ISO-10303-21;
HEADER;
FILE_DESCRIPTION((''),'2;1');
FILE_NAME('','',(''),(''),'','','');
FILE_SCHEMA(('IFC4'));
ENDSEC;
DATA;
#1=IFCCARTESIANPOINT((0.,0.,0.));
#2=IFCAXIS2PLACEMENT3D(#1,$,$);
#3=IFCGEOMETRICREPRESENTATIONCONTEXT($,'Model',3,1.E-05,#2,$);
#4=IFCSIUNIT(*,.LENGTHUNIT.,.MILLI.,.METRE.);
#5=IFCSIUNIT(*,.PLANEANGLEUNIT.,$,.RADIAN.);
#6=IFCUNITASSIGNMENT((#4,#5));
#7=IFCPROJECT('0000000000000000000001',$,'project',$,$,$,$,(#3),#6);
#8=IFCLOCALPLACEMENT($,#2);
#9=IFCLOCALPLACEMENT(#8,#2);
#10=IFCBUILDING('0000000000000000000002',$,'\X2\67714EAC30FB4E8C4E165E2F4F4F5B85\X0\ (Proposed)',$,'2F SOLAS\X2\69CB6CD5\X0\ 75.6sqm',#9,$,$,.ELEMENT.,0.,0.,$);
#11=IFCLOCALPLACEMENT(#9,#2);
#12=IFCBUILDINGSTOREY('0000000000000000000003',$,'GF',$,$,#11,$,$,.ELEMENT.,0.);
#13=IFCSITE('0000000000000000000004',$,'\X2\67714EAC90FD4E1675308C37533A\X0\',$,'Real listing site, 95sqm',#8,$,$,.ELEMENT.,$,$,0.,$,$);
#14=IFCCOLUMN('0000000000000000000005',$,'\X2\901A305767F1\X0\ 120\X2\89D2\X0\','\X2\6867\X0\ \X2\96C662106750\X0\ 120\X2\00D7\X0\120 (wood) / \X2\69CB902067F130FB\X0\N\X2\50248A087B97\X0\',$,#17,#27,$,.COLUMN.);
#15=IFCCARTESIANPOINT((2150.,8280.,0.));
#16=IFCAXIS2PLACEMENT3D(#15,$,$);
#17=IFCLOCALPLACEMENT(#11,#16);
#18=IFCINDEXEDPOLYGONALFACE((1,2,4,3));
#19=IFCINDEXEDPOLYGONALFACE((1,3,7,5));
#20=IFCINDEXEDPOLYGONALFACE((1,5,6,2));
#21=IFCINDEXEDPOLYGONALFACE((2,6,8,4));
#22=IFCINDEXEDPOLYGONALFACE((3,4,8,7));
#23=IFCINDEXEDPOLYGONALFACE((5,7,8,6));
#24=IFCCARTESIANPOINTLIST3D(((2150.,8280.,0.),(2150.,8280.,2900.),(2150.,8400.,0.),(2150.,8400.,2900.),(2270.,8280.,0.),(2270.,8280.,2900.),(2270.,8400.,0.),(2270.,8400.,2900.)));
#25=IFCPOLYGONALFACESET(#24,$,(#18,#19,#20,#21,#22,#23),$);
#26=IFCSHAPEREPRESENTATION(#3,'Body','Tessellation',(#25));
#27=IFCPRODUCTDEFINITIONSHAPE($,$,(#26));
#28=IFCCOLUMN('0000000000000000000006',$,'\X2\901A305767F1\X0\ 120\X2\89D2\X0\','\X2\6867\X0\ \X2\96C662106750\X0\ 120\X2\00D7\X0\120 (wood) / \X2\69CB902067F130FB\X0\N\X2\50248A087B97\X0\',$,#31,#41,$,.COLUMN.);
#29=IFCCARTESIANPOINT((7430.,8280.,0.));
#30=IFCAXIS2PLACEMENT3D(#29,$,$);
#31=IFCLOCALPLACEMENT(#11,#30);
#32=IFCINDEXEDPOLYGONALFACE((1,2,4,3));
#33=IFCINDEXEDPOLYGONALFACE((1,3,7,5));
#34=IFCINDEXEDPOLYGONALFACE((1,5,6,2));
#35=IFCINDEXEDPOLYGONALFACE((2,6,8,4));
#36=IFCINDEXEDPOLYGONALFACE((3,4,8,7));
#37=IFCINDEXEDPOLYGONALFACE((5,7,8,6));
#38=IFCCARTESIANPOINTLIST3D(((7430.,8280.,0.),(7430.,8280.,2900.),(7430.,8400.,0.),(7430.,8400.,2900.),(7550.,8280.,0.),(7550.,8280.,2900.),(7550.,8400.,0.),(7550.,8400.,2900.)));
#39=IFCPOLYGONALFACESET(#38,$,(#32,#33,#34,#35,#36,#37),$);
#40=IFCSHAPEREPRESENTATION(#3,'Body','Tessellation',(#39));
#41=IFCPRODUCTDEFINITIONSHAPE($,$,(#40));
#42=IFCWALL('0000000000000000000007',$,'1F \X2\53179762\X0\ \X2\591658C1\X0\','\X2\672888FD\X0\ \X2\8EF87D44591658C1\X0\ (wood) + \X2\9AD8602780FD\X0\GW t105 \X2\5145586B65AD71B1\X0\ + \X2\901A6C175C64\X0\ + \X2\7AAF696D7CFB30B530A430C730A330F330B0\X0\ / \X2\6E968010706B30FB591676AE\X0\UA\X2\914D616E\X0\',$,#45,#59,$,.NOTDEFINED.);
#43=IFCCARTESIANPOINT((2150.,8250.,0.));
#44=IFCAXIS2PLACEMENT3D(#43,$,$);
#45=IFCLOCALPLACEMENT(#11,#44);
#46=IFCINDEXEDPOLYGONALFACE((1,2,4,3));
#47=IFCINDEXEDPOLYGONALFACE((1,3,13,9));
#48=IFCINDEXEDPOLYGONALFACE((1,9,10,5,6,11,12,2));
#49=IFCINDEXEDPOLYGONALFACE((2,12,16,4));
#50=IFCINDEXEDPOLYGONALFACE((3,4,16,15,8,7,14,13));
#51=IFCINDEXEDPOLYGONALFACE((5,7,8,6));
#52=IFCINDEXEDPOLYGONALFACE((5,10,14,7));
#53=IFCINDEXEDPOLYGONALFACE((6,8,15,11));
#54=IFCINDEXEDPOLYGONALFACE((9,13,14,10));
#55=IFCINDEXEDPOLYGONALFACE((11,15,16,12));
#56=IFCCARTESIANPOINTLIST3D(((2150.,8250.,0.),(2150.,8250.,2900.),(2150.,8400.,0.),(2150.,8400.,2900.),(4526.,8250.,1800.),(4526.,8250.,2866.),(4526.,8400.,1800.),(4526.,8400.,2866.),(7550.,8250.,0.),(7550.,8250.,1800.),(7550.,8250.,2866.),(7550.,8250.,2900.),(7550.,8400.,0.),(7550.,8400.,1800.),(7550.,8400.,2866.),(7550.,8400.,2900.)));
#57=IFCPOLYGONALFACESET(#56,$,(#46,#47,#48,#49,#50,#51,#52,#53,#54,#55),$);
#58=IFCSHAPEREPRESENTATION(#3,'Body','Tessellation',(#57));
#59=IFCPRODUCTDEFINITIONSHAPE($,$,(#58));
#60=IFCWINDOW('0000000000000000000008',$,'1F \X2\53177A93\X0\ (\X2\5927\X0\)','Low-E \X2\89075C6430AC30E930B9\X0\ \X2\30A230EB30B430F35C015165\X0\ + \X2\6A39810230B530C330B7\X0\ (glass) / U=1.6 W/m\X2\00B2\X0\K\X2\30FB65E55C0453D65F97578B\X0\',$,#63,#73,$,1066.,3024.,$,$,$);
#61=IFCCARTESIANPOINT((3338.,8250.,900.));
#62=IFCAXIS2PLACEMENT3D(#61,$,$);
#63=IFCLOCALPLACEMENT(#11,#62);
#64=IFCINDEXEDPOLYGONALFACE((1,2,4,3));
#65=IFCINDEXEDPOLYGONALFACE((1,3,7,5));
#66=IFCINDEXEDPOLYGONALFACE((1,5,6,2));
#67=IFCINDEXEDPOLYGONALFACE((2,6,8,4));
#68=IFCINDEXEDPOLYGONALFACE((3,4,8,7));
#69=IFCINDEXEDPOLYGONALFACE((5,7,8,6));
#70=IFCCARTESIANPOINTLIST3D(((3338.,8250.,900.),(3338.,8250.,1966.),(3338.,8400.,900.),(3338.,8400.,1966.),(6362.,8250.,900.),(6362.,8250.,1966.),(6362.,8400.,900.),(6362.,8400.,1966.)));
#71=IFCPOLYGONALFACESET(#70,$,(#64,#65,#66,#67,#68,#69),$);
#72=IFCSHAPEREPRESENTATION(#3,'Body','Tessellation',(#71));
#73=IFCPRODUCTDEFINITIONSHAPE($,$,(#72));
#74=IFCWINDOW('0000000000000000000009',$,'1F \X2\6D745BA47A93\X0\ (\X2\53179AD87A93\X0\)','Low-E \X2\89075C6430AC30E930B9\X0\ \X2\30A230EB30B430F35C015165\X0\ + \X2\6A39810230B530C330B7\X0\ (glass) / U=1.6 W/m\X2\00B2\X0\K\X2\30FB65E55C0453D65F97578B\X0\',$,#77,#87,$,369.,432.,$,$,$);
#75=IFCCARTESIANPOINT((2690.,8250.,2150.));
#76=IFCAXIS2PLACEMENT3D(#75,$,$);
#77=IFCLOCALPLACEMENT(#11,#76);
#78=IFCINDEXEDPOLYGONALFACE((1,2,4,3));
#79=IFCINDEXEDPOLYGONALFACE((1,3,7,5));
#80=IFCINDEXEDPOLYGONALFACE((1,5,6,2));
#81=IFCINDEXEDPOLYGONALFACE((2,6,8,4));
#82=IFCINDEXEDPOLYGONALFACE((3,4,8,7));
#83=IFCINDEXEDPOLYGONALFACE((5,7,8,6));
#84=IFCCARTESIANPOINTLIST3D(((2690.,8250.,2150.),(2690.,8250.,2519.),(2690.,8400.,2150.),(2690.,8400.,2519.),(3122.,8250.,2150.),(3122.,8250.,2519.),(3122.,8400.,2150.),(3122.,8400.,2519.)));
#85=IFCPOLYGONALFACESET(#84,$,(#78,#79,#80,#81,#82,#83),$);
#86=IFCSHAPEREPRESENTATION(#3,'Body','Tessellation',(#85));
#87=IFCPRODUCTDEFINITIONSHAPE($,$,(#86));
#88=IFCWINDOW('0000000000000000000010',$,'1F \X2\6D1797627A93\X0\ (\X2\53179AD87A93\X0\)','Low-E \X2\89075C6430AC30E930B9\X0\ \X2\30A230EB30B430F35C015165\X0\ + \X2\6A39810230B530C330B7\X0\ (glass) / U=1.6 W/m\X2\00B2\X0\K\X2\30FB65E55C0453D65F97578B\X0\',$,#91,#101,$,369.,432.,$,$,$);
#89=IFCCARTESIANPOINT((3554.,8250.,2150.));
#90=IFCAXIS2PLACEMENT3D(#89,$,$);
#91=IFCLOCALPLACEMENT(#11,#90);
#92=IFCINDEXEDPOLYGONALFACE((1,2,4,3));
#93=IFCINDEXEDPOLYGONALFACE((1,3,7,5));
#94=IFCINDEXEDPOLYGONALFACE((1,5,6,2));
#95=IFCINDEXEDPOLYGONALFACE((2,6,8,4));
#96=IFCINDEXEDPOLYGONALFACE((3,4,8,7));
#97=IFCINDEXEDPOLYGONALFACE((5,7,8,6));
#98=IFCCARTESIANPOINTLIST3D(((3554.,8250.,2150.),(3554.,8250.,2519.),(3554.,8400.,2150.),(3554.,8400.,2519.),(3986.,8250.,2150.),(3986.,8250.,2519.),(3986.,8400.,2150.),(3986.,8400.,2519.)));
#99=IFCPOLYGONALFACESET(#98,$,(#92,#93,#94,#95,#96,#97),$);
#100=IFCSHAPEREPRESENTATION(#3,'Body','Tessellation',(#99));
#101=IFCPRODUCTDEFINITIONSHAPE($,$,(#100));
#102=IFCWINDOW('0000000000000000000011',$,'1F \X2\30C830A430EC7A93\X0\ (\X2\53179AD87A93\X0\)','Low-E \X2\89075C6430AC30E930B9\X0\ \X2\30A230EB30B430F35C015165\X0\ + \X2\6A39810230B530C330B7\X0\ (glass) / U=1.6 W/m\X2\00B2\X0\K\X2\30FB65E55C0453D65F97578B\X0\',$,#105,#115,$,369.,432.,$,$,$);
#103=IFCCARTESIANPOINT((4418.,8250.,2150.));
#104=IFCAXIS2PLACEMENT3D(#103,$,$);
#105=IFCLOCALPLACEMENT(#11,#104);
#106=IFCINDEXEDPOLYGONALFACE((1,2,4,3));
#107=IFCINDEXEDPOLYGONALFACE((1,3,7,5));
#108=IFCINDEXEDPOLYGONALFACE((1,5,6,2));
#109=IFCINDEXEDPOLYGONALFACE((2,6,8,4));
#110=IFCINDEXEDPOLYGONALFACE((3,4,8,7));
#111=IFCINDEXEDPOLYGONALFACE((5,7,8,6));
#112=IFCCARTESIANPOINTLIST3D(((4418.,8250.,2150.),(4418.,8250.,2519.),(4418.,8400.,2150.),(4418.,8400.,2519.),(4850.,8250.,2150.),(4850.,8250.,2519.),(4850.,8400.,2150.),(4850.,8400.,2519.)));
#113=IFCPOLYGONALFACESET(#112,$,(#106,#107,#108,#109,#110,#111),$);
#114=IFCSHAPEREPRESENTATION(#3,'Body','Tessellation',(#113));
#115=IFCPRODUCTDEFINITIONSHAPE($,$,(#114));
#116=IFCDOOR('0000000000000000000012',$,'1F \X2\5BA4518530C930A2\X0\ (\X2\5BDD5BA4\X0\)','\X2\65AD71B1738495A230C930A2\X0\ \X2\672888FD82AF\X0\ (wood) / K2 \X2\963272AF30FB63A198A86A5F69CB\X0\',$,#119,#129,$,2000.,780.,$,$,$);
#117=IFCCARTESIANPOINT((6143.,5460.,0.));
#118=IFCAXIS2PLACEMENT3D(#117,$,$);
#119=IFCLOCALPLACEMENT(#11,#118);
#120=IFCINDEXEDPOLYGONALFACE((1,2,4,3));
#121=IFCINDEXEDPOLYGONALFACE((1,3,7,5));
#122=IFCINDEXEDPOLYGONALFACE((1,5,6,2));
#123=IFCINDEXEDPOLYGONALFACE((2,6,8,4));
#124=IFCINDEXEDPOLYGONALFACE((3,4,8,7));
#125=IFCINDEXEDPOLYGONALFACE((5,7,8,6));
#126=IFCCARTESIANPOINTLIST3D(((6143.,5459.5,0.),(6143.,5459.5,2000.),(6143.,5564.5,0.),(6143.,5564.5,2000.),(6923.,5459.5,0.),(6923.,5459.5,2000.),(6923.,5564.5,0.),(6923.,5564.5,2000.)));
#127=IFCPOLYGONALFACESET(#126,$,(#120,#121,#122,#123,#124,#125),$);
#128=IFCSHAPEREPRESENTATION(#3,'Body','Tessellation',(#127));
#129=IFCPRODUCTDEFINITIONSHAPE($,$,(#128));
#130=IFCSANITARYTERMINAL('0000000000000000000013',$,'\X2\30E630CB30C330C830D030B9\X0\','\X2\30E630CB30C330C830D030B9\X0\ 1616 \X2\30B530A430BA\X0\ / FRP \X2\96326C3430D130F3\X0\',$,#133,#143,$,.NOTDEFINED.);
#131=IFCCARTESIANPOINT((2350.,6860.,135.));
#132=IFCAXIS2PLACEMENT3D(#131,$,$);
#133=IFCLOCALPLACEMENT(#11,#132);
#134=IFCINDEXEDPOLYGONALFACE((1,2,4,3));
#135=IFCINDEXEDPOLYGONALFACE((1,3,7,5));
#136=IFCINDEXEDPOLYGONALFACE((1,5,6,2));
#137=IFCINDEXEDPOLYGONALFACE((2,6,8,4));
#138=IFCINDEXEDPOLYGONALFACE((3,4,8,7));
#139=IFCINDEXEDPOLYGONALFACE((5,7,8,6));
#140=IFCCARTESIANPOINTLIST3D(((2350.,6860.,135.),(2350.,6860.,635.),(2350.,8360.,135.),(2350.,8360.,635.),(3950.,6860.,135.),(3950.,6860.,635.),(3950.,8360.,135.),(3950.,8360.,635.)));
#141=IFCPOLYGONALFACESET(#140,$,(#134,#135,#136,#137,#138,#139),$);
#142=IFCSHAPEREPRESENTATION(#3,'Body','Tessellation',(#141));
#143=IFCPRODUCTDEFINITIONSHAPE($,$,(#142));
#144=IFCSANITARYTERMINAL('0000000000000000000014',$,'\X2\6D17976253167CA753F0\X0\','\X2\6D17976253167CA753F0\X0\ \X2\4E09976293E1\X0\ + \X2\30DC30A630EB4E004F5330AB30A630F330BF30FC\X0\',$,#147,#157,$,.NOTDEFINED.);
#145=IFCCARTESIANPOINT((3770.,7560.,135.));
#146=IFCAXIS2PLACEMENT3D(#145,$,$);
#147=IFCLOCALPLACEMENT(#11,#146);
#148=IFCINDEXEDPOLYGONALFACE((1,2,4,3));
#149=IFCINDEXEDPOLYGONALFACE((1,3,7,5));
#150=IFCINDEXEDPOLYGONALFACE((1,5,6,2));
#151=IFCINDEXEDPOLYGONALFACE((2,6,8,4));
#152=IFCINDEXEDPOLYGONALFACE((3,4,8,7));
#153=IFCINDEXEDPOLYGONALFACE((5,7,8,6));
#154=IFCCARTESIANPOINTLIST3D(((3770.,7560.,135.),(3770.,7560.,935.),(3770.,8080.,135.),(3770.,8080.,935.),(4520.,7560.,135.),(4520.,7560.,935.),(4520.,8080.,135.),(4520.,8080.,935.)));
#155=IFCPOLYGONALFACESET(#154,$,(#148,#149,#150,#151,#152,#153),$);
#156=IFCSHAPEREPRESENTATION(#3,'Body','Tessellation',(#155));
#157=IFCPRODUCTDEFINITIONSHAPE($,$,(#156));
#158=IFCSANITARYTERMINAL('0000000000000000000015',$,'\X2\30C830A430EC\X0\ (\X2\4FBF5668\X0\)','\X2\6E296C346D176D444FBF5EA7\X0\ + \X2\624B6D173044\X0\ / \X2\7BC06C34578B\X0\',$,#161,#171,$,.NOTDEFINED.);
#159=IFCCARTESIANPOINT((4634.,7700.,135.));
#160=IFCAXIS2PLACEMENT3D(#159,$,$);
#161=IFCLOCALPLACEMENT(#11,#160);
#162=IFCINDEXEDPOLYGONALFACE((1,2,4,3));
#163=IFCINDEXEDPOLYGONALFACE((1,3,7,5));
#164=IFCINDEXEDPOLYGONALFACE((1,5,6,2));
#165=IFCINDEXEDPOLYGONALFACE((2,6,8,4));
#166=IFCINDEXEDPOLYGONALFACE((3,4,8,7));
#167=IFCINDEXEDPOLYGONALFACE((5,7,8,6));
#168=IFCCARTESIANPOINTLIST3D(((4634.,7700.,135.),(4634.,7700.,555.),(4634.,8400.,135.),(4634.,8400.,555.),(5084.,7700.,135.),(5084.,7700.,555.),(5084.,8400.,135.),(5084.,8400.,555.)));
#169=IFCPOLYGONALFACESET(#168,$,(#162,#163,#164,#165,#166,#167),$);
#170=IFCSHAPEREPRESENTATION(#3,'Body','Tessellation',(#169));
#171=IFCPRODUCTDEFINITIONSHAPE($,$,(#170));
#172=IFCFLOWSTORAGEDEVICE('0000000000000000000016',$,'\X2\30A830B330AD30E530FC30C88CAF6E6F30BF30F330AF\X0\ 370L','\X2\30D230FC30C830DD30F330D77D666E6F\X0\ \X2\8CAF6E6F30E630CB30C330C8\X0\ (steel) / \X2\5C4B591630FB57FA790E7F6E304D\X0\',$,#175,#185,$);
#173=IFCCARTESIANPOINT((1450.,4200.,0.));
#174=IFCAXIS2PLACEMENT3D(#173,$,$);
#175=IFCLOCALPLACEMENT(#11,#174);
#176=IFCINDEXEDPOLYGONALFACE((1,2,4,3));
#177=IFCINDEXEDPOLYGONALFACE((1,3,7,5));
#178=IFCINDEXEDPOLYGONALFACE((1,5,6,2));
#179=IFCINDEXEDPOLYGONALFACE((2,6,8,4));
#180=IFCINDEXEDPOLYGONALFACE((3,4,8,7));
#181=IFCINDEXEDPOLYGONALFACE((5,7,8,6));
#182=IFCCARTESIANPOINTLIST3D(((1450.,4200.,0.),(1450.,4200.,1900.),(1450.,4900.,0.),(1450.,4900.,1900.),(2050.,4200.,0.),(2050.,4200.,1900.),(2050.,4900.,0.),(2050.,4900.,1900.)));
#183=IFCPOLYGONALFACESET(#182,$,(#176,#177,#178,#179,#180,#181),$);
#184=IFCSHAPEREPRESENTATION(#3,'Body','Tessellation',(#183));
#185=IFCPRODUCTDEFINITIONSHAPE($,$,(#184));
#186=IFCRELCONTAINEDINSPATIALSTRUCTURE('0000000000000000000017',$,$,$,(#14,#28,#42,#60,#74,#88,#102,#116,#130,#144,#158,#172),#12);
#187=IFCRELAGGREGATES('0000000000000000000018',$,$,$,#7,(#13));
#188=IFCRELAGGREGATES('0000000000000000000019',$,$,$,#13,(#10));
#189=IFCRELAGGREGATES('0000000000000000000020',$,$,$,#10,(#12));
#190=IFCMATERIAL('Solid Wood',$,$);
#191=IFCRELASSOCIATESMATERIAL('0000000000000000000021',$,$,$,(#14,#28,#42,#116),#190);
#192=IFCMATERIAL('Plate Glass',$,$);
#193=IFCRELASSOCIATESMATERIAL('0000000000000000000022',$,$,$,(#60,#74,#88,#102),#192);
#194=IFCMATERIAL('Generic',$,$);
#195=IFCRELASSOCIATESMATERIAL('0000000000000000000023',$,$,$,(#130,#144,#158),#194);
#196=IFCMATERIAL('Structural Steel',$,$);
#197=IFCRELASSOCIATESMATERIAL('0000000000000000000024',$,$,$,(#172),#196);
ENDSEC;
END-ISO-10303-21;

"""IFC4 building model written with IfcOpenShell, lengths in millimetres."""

from ifc_helpers import new_model, si_unit, frame, frame_2d, origin, place, context, project, spatial, rectangle, extrude, material, element, fill, save


model = new_model("IFC4")

# Units and contexts
model_context = context("Model", 3, precision=1e-05, world=origin())
ifc_project = project(units=[si_unit("LENGTHUNIT", "METRE", prefix="MILLI"), si_unit("PLANEANGLEUNIT", "RADIAN")], contexts=[model_context])

# Site, building, storey
site_placement = place(None, origin())
site = spatial("IfcSite", under=ifc_project, at=site_placement, Name="東京都世田谷区", ObjectType="Real listing site, 95sqm", CompositionType="ELEMENT", RefElevation=0.0)
building_placement = place(site_placement, origin())
building = spatial("IfcBuilding", under=site, at=building_placement, Name="東京・二世帯住宅 (Proposed)", ObjectType="2F SOLAS構法 75.6sqm", CompositionType="ELEMENT", ElevationOfRefHeight=0.0, ElevationOfTerrain=0.0)
storey_placement = place(building_placement, origin())
storey = spatial("IfcBuildingStorey", under=building, at=storey_placement, Name="GF", CompositionType="ELEMENT", Elevation=0.0)

# Columns
ifc_material_1 = material(Name="Solid Wood")
column_1_placement = place(storey_placement, frame((2150.0, 8280.0, 0.0)))
element("IfcColumn", 1, at=column_1_placement, inside=storey, material=ifc_material_1, Name="通し柱 120角", Description="桧 集成材 120×120 (wood) / 構造柱・N値計算", PredefinedType="COLUMN", context=model_context, shape_type="SweptSolid", body=[
    extrude(rectangle(XDim=120.0, YDim=120.0, at=frame_2d((60.0, 60.0))), frame((2150.0, 8280.0, 0.0)), (0.0, 0.0, 1.0), 2900.0),
])
column_2_placement = place(storey_placement, frame((7430.0, 8280.0, 0.0)))
element("IfcColumn", 2, at=column_2_placement, inside=storey, material=ifc_material_1, Name="通し柱 120角", Description="桧 集成材 120×120 (wood) / 構造柱・N値計算", PredefinedType="COLUMN", context=model_context, shape_type="SweptSolid", body=[
    extrude(rectangle(XDim=120.0, YDim=120.0, at=frame_2d((60.0, 60.0))), frame((7430.0, 8280.0, 0.0)), (0.0, 0.0, 1.0), 2900.0),
])

# Wall, openings, windows
wall_1_placement = place(storey_placement, frame((2150.0, 8250.0, 0.0)))
wall_1 = element("IfcWall", 3, at=wall_1_placement, inside=storey, material=ifc_material_1, Name="1F 北面 外壁", Description="木製 軸組外壁 (wood) + 高性能GW t105 充填断熱 + 通気層 + 窯業系サイディング / 準耐火・外皮UA配慮", PredefinedType="NOTDEFINED", context=model_context, shape_type="SweptSolid", body=[
    extrude(rectangle(XDim=5400.0, YDim=150.0, at=frame_2d((2700.0, 75.0))), frame((2150.0, 8250.0, 0.0)), (0.0, 0.0, 1.0), 2900.0),
])
opening_1_placement = place(storey_placement, frame((3338.0, 8250.0, 900.0)))
opening_1 = element("IfcOpeningElement", 4, at=opening_1_placement, cuts=wall_1, PredefinedType="NOTDEFINED", context=model_context, shape_type="SweptSolid", body=[
    extrude(rectangle(XDim=3024.0, YDim=150.0, at=frame_2d((1512.0, 75.0))), frame((3338.0, 8250.0, 900.0)), (0.0, 0.0, 1.0), 1066.0),
])
opening_2_placement = place(storey_placement, frame((2690.0, 8250.0, 2150.0)))
opening_2 = element("IfcOpeningElement", 5, at=opening_2_placement, cuts=wall_1, PredefinedType="NOTDEFINED", context=model_context, shape_type="SweptSolid", body=[
    extrude(rectangle(XDim=432.0, YDim=150.0, at=frame_2d((216.0, 75.0))), frame((2690.0, 8250.0, 2150.0)), (0.0, 0.0, 1.0), 369.0),
])
opening_3_placement = place(storey_placement, frame((3554.0, 8250.0, 2150.0)))
opening_3 = element("IfcOpeningElement", 6, at=opening_3_placement, cuts=wall_1, PredefinedType="NOTDEFINED", context=model_context, shape_type="SweptSolid", body=[
    extrude(rectangle(XDim=432.0, YDim=150.0, at=frame_2d((216.0, 75.0))), frame((3554.0, 8250.0, 2150.0)), (0.0, 0.0, 1.0), 369.0),
])
opening_4_placement = place(storey_placement, frame((4418.0, 8250.0, 2150.0)))
opening_4 = element("IfcOpeningElement", 7, at=opening_4_placement, cuts=wall_1, PredefinedType="NOTDEFINED", context=model_context, shape_type="SweptSolid", body=[
    extrude(rectangle(XDim=432.0, YDim=150.0, at=frame_2d((216.0, 75.0))), frame((4418.0, 8250.0, 2150.0)), (0.0, 0.0, 1.0), 369.0),
])
ifc_material_2 = material(Name="Plate Glass")
window_1_placement = place(storey_placement, frame((3338.0, 8250.0, 900.0)))
window_1 = element("IfcWindow", 8, at=window_1_placement, inside=storey, material=ifc_material_2, Name="1F 北窓 (大)", Description="Low-E 複層ガラス アルゴン封入 + 樹脂サッシ (glass) / U=1.6 W/m²K・日射取得型", OverallHeight=1066.0, OverallWidth=3024.0, context=model_context, shape_type="SweptSolid", body=[
    extrude(rectangle(XDim=3024.0, YDim=150.0, at=frame_2d((1512.0, 75.0))), frame((3338.0, 8250.0, 900.0)), (0.0, 0.0, 1.0), 1066.0),
])
fill(opening_1, window_1)
window_2_placement = place(storey_placement, frame((2690.0, 8250.0, 2150.0)))
window_2 = element("IfcWindow", 9, at=window_2_placement, inside=storey, material=ifc_material_2, Name="1F 浴室窓 (北高窓)", Description="Low-E 複層ガラス アルゴン封入 + 樹脂サッシ (glass) / U=1.6 W/m²K・日射取得型", OverallHeight=369.0, OverallWidth=432.0, context=model_context, shape_type="SweptSolid", body=[
    extrude(rectangle(XDim=432.0, YDim=150.0, at=frame_2d((216.0, 75.0))), frame((2690.0, 8250.0, 2150.0)), (0.0, 0.0, 1.0), 369.0),
])
fill(opening_2, window_2)
window_3_placement = place(storey_placement, frame((3554.0, 8250.0, 2150.0)))
window_3 = element("IfcWindow", 10, at=window_3_placement, inside=storey, material=ifc_material_2, Name="1F 洗面窓 (北高窓)", Description="Low-E 複層ガラス アルゴン封入 + 樹脂サッシ (glass) / U=1.6 W/m²K・日射取得型", OverallHeight=369.0, OverallWidth=432.0, context=model_context, shape_type="SweptSolid", body=[
    extrude(rectangle(XDim=432.0, YDim=150.0, at=frame_2d((216.0, 75.0))), frame((3554.0, 8250.0, 2150.0)), (0.0, 0.0, 1.0), 369.0),
])
fill(opening_3, window_3)
window_4_placement = place(storey_placement, frame((4418.0, 8250.0, 2150.0)))
window_4 = element("IfcWindow", 11, at=window_4_placement, inside=storey, material=ifc_material_2, Name="1F トイレ窓 (北高窓)", Description="Low-E 複層ガラス アルゴン封入 + 樹脂サッシ (glass) / U=1.6 W/m²K・日射取得型", OverallHeight=369.0, OverallWidth=432.0, context=model_context, shape_type="SweptSolid", body=[
    extrude(rectangle(XDim=432.0, YDim=150.0, at=frame_2d((216.0, 75.0))), frame((4418.0, 8250.0, 2150.0)), (0.0, 0.0, 1.0), 369.0),
])
fill(opening_4, window_4)

# Door
door_1_placement = place(storey_placement, frame((6143.0, 5460.0, 0.0)))
element("IfcDoor", 12, at=door_1_placement, inside=storey, material=ifc_material_1, Name="1F 室内ドア (寝室)", Description="断熱玄関ドア 木製芯 (wood) / K2 防犯・採風機構", OverallHeight=2000.0, OverallWidth=780.0, context=model_context, shape_type="SweptSolid", body=[
    extrude(rectangle(XDim=780.0, YDim=105.0, at=frame_2d((390.0, 52.0))), frame((6143.0, 5460.0, 0.0)), (0.0, 0.0, 1.0), 2000.0),
])

# Sanitary terminals
ifc_material_3 = material(Name="Generic")
sanitary_terminal_1_placement = place(storey_placement, frame((2350.0, 6860.0, 135.0)))
element("IfcSanitaryTerminal", 13, at=sanitary_terminal_1_placement, inside=storey, material=ifc_material_3, Name="ユニットバス", Description="ユニットバス 1616 サイズ / FRP 防水パン", PredefinedType="NOTDEFINED", context=model_context, shape_type="SweptSolid", body=[
    extrude(rectangle(XDim=1600.0, YDim=1500.0, at=frame_2d((800.0, 750.0))), frame((2350.0, 6860.0, 135.0)), (0.0, 0.0, 1.0), 500.0),
])
sanitary_terminal_2_placement = place(storey_placement, frame((3770.0, 7560.0, 135.0)))
element("IfcSanitaryTerminal", 14, at=sanitary_terminal_2_placement, inside=storey, material=ifc_material_3, Name="洗面化粧台", Description="洗面化粧台 三面鏡 + ボウル一体カウンター", PredefinedType="NOTDEFINED", context=model_context, shape_type="SweptSolid", body=[
    extrude(rectangle(XDim=750.0, YDim=520.0, at=frame_2d((375.0, 260.0))), frame((3770.0, 7560.0, 135.0)), (0.0, 0.0, 1.0), 800.0),
])
sanitary_terminal_3_placement = place(storey_placement, frame((4634.0, 7700.0, 135.0)))
element("IfcSanitaryTerminal", 15, at=sanitary_terminal_3_placement, inside=storey, material=ifc_material_3, Name="トイレ (便器)", Description="温水洗浄便座 + 手洗い / 節水型", PredefinedType="NOTDEFINED", context=model_context, shape_type="SweptSolid", body=[
    extrude(rectangle(XDim=450.0, YDim=700.0, at=frame_2d((225.0, 350.0))), frame((4634.0, 7700.0, 135.0)), (0.0, 0.0, 1.0), 420.0),
])

# Flow storage device
ifc_material_4 = material(Name="Structural Steel")
flow_storage_device_placement = place(storey_placement, frame((1450.0, 4200.0, 0.0)))
element("IfcFlowStorageDevice", 16, at=flow_storage_device_placement, inside=storey, material=ifc_material_4, Name="エコキュート貯湯タンク 370L", Description="ヒートポンプ給湯 貯湯ユニット (steel) / 屋外・基礎置き", context=model_context, shape_type="SweptSolid", body=[
    extrude(rectangle(XDim=600.0, YDim=700.0, at=frame_2d((300.0, 350.0))), frame((1450.0, 4200.0, 0.0)), (0.0, 0.0, 1.0), 1900.0),
])

save(model, "model.ifc")
